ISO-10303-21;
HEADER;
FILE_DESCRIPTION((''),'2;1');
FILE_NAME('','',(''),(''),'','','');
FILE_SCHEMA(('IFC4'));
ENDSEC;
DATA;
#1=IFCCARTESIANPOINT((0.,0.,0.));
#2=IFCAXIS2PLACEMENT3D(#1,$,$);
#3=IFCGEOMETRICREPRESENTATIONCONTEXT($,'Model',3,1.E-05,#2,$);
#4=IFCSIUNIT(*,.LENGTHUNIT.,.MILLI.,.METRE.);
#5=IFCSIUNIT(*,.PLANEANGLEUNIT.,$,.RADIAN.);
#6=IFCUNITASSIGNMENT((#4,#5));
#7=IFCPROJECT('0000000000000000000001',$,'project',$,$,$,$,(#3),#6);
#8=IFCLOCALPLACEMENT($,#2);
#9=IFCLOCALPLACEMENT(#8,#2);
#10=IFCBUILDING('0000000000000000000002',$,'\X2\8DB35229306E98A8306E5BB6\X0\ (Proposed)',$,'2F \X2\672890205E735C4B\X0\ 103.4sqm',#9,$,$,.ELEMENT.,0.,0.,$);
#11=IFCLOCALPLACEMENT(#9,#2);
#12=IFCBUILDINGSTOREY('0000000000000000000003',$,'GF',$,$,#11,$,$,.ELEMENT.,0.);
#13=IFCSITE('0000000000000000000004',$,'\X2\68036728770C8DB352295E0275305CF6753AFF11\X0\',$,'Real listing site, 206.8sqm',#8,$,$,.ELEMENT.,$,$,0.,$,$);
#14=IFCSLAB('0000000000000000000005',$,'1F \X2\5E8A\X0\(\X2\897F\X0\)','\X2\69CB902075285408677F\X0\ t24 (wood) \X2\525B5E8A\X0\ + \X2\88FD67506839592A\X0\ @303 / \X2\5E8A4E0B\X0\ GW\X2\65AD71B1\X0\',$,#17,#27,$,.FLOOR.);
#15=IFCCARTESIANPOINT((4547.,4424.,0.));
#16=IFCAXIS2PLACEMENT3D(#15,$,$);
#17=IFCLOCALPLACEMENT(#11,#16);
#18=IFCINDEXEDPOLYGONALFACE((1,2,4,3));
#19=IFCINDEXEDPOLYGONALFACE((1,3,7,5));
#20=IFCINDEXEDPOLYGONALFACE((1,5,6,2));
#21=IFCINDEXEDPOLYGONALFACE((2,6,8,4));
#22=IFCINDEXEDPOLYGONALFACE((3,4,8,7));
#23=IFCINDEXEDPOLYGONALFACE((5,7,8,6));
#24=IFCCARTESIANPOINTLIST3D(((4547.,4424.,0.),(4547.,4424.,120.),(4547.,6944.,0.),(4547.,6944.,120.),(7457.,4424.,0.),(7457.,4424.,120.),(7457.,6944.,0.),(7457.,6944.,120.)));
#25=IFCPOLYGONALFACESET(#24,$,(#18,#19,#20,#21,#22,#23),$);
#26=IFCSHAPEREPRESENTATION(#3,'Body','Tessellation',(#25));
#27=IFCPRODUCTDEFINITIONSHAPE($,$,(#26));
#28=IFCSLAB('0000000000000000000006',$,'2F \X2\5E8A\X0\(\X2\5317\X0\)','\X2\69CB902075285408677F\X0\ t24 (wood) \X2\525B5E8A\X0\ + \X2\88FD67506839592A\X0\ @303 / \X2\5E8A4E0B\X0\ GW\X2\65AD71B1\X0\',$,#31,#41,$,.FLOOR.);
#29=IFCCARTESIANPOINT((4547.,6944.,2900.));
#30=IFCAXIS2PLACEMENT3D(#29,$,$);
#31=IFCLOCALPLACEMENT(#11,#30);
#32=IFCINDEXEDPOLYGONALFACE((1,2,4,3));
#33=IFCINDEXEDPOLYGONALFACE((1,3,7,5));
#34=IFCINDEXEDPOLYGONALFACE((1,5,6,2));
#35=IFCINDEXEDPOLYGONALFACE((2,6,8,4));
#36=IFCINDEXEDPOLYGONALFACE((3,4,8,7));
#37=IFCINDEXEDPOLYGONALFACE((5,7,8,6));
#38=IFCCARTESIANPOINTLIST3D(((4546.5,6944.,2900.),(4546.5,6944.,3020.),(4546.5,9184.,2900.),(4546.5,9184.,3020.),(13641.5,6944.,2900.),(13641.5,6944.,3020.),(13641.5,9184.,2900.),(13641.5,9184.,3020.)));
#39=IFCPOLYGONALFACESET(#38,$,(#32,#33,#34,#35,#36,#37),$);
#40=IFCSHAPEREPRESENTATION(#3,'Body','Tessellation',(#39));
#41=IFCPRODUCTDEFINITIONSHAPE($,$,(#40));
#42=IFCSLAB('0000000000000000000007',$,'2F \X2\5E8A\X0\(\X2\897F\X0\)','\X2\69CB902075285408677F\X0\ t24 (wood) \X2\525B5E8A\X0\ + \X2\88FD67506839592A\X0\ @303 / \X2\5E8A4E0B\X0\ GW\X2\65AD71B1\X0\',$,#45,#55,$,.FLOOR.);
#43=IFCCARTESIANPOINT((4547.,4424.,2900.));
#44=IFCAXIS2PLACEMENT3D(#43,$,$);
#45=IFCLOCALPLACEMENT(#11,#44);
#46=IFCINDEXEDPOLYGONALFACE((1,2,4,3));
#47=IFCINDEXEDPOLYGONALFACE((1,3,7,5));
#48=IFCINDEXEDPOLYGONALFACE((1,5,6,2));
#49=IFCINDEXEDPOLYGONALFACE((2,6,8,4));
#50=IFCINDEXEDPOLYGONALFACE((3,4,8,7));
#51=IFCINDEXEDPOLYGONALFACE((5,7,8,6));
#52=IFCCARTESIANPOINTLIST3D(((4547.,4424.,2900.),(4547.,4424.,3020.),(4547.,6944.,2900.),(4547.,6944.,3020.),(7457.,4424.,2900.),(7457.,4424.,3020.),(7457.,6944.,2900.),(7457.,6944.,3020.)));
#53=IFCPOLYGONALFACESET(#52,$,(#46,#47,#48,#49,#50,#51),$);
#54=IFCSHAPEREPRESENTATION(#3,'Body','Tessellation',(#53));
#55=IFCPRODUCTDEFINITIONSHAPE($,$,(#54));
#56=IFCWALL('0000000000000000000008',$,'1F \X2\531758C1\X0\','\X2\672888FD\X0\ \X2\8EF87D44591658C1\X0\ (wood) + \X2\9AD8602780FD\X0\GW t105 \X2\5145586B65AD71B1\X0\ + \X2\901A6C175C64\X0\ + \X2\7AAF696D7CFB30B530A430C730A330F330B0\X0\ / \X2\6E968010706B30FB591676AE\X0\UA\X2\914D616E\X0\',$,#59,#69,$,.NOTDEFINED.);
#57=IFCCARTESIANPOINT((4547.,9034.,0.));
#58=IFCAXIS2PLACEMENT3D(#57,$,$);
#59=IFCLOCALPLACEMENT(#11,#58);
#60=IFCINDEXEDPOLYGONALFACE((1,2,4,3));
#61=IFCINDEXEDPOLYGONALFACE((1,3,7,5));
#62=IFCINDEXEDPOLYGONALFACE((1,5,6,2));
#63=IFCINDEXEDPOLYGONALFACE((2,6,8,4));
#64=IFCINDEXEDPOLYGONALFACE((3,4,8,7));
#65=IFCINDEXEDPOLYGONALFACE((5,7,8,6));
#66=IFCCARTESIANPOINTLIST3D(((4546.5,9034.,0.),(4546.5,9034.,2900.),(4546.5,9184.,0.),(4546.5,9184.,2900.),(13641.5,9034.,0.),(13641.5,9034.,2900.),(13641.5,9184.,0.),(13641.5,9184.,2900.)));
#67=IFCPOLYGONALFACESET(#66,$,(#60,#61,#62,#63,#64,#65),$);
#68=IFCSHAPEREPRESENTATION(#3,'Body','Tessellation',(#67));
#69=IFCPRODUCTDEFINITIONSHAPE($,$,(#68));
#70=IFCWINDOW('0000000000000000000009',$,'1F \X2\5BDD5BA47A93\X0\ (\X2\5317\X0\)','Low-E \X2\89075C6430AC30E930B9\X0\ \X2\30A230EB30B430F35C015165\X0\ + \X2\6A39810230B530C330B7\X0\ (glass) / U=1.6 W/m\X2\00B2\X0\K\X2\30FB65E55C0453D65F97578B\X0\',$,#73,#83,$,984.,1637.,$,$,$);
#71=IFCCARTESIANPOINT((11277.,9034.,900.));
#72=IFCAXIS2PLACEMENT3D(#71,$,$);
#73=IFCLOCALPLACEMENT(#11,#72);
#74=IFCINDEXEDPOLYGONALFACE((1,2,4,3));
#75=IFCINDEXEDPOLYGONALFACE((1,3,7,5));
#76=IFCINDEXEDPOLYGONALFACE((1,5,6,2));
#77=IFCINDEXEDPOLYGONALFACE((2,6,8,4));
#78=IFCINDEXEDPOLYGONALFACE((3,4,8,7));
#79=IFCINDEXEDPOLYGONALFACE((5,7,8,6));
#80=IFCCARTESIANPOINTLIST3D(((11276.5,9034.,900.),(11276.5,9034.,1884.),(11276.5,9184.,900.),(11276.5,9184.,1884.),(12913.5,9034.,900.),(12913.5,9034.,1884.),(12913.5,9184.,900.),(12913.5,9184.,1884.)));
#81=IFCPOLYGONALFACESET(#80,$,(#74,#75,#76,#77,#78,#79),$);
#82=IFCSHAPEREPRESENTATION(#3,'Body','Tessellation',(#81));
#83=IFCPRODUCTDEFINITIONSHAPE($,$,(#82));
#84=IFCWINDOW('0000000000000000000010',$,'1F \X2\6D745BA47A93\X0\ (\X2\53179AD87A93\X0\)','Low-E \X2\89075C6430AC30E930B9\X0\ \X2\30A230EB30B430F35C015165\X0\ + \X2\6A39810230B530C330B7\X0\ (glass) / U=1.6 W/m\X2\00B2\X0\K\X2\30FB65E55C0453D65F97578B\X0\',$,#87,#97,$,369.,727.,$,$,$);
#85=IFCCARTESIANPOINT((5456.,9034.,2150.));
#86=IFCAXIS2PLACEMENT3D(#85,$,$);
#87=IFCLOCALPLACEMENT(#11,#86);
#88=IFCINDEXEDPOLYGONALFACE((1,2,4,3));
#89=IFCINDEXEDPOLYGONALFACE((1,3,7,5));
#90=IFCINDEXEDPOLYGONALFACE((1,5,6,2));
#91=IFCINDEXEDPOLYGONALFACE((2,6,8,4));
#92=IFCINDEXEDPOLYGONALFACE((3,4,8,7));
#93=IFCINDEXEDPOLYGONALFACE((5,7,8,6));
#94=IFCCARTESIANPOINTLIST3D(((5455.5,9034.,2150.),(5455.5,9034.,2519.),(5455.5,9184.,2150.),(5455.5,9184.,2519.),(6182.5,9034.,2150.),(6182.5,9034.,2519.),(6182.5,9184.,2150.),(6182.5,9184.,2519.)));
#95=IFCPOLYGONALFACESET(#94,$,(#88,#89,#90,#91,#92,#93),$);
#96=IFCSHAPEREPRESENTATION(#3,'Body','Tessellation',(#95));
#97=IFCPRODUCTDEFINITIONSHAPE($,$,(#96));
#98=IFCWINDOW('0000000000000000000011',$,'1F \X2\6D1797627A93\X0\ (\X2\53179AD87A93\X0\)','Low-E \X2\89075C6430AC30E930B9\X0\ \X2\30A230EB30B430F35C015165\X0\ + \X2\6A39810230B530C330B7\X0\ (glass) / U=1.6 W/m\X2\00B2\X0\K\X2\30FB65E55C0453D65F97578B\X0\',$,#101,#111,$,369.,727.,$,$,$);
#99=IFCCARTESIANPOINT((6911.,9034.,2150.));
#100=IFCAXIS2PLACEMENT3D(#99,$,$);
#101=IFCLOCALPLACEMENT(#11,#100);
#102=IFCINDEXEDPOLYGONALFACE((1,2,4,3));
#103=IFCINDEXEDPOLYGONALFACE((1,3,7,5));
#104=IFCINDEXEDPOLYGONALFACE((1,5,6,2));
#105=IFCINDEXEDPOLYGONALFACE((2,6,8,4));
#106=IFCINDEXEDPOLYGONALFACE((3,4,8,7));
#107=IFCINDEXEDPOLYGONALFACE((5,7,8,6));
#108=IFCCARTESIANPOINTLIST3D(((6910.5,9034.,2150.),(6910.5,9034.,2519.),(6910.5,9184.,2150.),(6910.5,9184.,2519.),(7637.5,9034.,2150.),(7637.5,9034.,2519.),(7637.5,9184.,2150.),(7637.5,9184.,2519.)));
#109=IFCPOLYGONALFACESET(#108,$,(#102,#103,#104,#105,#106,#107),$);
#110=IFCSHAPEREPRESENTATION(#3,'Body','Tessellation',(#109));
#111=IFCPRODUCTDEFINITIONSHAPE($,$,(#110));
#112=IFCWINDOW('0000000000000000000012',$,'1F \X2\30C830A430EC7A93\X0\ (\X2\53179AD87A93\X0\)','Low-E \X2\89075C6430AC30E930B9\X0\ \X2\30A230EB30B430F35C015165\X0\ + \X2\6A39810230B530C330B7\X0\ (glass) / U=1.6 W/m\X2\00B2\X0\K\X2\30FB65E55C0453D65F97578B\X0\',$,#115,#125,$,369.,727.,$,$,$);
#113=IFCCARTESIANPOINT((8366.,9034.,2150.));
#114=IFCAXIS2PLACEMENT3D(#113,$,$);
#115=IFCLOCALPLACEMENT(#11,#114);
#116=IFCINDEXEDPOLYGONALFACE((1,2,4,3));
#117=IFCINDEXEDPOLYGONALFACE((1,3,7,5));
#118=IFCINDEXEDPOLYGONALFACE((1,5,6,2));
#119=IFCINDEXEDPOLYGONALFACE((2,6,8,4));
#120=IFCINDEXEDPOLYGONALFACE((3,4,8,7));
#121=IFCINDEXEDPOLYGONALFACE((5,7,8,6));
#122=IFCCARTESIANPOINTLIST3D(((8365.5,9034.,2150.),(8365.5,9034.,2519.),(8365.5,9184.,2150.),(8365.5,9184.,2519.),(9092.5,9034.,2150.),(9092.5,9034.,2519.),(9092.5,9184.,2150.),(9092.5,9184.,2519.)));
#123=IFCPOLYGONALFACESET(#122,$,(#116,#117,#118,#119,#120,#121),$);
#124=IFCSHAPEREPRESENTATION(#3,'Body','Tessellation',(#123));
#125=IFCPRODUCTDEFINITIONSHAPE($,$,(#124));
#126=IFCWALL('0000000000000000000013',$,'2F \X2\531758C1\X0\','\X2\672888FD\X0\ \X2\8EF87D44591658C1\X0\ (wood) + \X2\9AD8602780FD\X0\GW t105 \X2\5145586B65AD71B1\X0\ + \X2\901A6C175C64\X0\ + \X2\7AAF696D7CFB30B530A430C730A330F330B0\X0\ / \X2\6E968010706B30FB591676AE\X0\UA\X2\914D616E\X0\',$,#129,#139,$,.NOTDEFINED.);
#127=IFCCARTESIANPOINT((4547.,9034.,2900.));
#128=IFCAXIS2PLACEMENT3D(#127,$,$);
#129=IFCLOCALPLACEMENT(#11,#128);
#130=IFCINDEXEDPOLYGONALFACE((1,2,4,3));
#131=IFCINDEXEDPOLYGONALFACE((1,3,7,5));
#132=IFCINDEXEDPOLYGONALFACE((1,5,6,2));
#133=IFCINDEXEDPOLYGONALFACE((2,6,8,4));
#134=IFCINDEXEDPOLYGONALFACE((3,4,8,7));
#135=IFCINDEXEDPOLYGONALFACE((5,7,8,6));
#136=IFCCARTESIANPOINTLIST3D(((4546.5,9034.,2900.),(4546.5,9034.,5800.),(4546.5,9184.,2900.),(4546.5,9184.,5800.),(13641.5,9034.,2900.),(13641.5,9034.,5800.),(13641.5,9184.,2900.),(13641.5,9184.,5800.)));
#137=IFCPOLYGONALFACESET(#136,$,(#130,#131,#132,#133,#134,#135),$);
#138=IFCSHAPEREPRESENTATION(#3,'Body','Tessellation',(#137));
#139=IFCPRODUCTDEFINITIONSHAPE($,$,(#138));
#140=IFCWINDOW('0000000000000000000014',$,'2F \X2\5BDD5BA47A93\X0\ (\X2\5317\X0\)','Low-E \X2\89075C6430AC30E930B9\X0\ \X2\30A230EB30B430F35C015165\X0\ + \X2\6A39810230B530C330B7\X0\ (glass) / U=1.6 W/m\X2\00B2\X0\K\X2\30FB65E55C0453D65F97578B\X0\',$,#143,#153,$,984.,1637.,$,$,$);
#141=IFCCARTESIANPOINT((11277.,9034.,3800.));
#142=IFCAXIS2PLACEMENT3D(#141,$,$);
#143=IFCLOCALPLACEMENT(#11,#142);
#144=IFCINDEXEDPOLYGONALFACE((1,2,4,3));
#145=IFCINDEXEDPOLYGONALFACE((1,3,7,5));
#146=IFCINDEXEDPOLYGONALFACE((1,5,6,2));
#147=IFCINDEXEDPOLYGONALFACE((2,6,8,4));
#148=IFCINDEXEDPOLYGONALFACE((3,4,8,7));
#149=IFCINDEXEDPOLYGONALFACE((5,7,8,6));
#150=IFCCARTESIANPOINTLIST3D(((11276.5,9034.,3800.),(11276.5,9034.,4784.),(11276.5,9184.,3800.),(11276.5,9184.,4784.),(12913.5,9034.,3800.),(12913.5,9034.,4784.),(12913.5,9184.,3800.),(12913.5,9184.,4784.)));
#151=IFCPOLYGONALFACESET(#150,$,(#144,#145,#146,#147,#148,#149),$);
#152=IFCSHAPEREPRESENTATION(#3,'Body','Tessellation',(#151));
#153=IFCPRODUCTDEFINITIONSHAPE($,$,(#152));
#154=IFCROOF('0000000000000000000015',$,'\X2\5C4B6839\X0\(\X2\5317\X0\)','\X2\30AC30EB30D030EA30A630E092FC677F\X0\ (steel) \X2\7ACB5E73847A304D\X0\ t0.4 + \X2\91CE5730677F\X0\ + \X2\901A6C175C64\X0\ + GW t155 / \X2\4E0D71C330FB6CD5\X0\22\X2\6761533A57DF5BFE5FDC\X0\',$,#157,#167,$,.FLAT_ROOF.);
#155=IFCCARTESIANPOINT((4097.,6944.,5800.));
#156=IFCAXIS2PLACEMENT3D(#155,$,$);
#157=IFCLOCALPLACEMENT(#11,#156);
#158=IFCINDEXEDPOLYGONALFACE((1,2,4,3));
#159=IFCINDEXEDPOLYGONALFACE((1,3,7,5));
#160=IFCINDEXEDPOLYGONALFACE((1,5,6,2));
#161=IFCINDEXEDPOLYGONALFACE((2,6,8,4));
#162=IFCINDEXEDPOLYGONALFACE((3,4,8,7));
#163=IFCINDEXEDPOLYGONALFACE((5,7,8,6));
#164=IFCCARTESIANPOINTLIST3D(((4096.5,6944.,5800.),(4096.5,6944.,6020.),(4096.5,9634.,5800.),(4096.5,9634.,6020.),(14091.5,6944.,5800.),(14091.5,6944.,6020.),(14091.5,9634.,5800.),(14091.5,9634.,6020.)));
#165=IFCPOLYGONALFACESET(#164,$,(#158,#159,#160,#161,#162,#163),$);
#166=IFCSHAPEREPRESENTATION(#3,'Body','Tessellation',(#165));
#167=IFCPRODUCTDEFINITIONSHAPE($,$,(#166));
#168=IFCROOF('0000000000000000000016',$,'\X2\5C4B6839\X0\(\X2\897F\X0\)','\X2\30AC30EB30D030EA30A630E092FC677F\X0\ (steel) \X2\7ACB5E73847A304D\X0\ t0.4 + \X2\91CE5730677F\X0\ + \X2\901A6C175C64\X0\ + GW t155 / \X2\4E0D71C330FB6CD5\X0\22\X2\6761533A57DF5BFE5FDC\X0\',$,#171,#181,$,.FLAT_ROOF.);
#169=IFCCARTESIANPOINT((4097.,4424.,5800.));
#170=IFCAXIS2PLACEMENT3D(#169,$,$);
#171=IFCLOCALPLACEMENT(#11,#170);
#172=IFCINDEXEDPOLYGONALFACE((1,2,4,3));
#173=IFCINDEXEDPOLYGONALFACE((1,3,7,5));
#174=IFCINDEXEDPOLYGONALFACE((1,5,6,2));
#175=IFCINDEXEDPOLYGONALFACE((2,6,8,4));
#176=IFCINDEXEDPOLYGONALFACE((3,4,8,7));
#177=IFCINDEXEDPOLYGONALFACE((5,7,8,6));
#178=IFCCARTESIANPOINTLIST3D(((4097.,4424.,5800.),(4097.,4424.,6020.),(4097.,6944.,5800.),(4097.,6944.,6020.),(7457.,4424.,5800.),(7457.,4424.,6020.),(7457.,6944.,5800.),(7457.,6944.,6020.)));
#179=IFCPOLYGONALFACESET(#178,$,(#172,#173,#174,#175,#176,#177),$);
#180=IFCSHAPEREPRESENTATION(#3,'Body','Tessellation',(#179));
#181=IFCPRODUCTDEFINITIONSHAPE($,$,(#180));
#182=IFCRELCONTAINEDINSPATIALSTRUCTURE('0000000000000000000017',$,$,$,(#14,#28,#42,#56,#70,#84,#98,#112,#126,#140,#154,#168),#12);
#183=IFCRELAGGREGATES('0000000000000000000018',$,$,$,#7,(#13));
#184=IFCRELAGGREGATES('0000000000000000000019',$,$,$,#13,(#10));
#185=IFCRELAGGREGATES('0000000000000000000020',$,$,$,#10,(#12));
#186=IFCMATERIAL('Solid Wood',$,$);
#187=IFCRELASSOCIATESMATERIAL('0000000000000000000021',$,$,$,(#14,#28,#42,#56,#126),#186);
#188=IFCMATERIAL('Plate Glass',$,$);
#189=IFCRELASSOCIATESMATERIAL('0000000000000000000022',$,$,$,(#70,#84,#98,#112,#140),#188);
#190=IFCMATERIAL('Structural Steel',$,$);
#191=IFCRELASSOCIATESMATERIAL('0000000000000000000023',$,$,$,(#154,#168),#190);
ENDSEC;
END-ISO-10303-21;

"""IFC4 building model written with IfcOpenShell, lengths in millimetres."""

from ifc_helpers import new_model, si_unit, frame, frame_2d, origin, place, context, project, spatial, rectangle, extrude, material, element, fill, save


model = new_model("IFC4")

# Units and contexts
model_context = context("Model", 3, precision=1e-05, world=origin())
ifc_project = project(units=[si_unit("LENGTHUNIT", "METRE", prefix="MILLI"), si_unit("PLANEANGLEUNIT", "RADIAN")], contexts=[model_context])

# Site, building, storey
site_placement = place(None, origin())
site = spatial("IfcSite", under=ifc_project, at=site_placement, Name="栃木県足利市田島町１", ObjectType="Real listing site, 206.8sqm", CompositionType="ELEMENT", RefElevation=0.0)
building_placement = place(site_placement, origin())
building = spatial("IfcBuilding", under=site, at=building_placement, Name="足利の風の家 (Proposed)", ObjectType="2F 木造平屋 103.4sqm", CompositionType="ELEMENT", ElevationOfRefHeight=0.0, ElevationOfTerrain=0.0)
storey_placement = place(building_placement, origin())
storey = spatial("IfcBuildingStorey", under=building, at=storey_placement, Name="GF", CompositionType="ELEMENT", Elevation=0.0)

# Slabs
ifc_material_1 = material(Name="Solid Wood")
slab_1_placement = place(storey_placement, frame((4547.0, 4424.0, 0.0)))
element("IfcSlab", 1, at=slab_1_placement, inside=storey, material=ifc_material_1, Name="1F 床(西)", Description="構造用合板 t24 (wood) 剛床 + 製材根太 @303 / 床下 GW断熱", PredefinedType="FLOOR", context=model_context, shape_type="SweptSolid", body=[
    extrude(rectangle(XDim=2910.0, YDim=2520.0, at=frame_2d((1455.0, 1260.0))), frame((4547.0, 4424.0, 0.0)), (0.0, 0.0, 1.0), 120.0),
])
slab_2_placement = place(storey_placement, frame((4547.0, 6944.0, 2900.0)))
element("IfcSlab", 2, at=slab_2_placement, inside=storey, material=ifc_material_1, Name="2F 床(北)", Description="構造用合板 t24 (wood) 剛床 + 製材根太 @303 / 床下 GW断熱", PredefinedType="FLOOR", context=model_context, shape_type="SweptSolid", body=[
    extrude(rectangle(XDim=9095.0, YDim=2240.0, at=frame_2d((4547.0, 1120.0))), frame((4547.0, 6944.0, 2900.0)), (0.0, 0.0, 1.0), 120.0),
])
slab_3_placement = place(storey_placement, frame((4547.0, 4424.0, 2900.0)))
element("IfcSlab", 3, at=slab_3_placement, inside=storey, material=ifc_material_1, Name="2F 床(西)", Description="構造用合板 t24 (wood) 剛床 + 製材根太 @303 / 床下 GW断熱", PredefinedType="FLOOR", context=model_context, shape_type="SweptSolid", body=[
    extrude(rectangle(XDim=2910.0, YDim=2520.0, at=frame_2d((1455.0, 1260.0))), frame((4547.0, 4424.0, 2900.0)), (0.0, 0.0, 1.0), 120.0),
])

# Wall, openings, windows
wall_1_placement = place(storey_placement, frame((4547.0, 9034.0, 0.0)))
wall_1 = element("IfcWall", 4, at=wall_1_placement, inside=storey, material=ifc_material_1, Name="1F 北壁", Description="木製 軸組外壁 (wood) + 高性能GW t105 充填断熱 + 通気層 + 窯業系サイディング / 準耐火・外皮UA配慮", PredefinedType="NOTDEFINED", context=model_context, shape_type="SweptSolid", body=[
    extrude(rectangle(XDim=9095.0, YDim=150.0, at=frame_2d((4547.0, 75.0))), frame((4547.0, 9034.0, 0.0)), (0.0, 0.0, 1.0), 2900.0),
])
opening_1_placement = place(storey_placement, frame((11277.0, 9034.0, 900.0)))
opening_1 = element("IfcOpeningElement", 5, at=opening_1_placement, cuts=wall_1, PredefinedType="NOTDEFINED", context=model_context, shape_type="SweptSolid", body=[
    extrude(rectangle(XDim=1637.0, YDim=150.0, at=frame_2d((818.0, 75.0))), frame((11277.0, 9034.0, 900.0)), (0.0, 0.0, 1.0), 984.0),
])
opening_2_placement = place(storey_placement, frame((5456.0, 9034.0, 2150.0)))
opening_2 = element("IfcOpeningElement", 6, at=opening_2_placement, cuts=wall_1, PredefinedType="NOTDEFINED", context=model_context, shape_type="SweptSolid", body=[
    extrude(rectangle(XDim=727.0, YDim=150.0, at=frame_2d((363.0, 75.0))), frame((5456.0, 9034.0, 2150.0)), (0.0, 0.0, 1.0), 369.0),
])
opening_3_placement = place(storey_placement, frame((6911.0, 9034.0, 2150.0)))
opening_3 = element("IfcOpeningElement", 7, at=opening_3_placement, cuts=wall_1, PredefinedType="NOTDEFINED", context=model_context, shape_type="SweptSolid", body=[
    extrude(rectangle(XDim=727.0, YDim=150.0, at=frame_2d((363.0, 75.0))), frame((6911.0, 9034.0, 2150.0)), (0.0, 0.0, 1.0), 369.0),
])
opening_4_placement = place(storey_placement, frame((8366.0, 9034.0, 2150.0)))
opening_4 = element("IfcOpeningElement", 8, at=opening_4_placement, cuts=wall_1, PredefinedType="NOTDEFINED", context=model_context, shape_type="SweptSolid", body=[
    extrude(rectangle(XDim=727.0, YDim=150.0, at=frame_2d((363.0, 75.0))), frame((8366.0, 9034.0, 2150.0)), (0.0, 0.0, 1.0), 369.0),
])
ifc_material_2 = material(Name="Plate Glass")
window_1_placement = place(storey_placement, frame((11277.0, 9034.0, 900.0)))
window_1 = element("IfcWindow", 9, at=window_1_placement, inside=storey, material=ifc_material_2, Name="1F 寝室窓 (北)", Description="Low-E 複層ガラス アルゴン封入 + 樹脂サッシ (glass) / U=1.6 W/m²K・日射取得型", OverallHeight=984.0, OverallWidth=1637.0, context=model_context, shape_type="SweptSolid", body=[
    extrude(rectangle(XDim=1637.0, YDim=150.0, at=frame_2d((818.0, 75.0))), frame((11277.0, 9034.0, 900.0)), (0.0, 0.0, 1.0), 984.0),
])
fill(opening_1, window_1)
window_2_placement = place(storey_placement, frame((5456.0, 9034.0, 2150.0)))
window_2 = element("IfcWindow", 10, at=window_2_placement, inside=storey, material=ifc_material_2, Name="1F 浴室窓 (北高窓)", Description="Low-E 複層ガラス アルゴン封入 + 樹脂サッシ (glass) / U=1.6 W/m²K・日射取得型", OverallHeight=369.0, OverallWidth=727.0, context=model_context, shape_type="SweptSolid", body=[
    extrude(rectangle(XDim=727.0, YDim=150.0, at=frame_2d((363.0, 75.0))), frame((5456.0, 9034.0, 2150.0)), (0.0, 0.0, 1.0), 369.0),
])
fill(opening_2, window_2)
window_3_placement = place(storey_placement, frame((6911.0, 9034.0, 2150.0)))
window_3 = element("IfcWindow", 11, at=window_3_placement, inside=storey, material=ifc_material_2, Name="1F 洗面窓 (北高窓)", Description="Low-E 複層ガラス アルゴン封入 + 樹脂サッシ (glass) / U=1.6 W/m²K・日射取得型", OverallHeight=369.0, OverallWidth=727.0, context=model_context, shape_type="SweptSolid", body=[
    extrude(rectangle(XDim=727.0, YDim=150.0, at=frame_2d((363.0, 75.0))), frame((6911.0, 9034.0, 2150.0)), (0.0, 0.0, 1.0), 369.0),
])
fill(opening_3, window_3)
window_4_placement = place(storey_placement, frame((8366.0, 9034.0, 2150.0)))
window_4 = element("IfcWindow", 12, at=window_4_placement, inside=storey, material=ifc_material_2, Name="1F トイレ窓 (北高窓)", Description="Low-E 複層ガラス アルゴン封入 + 樹脂サッシ (glass) / U=1.6 W/m²K・日射取得型", OverallHeight=369.0, OverallWidth=727.0, context=model_context, shape_type="SweptSolid", body=[
    extrude(rectangle(XDim=727.0, YDim=150.0, at=frame_2d((363.0, 75.0))), frame((8366.0, 9034.0, 2150.0)), (0.0, 0.0, 1.0), 369.0),
])
fill(opening_4, window_4)

# Wall, opening, window
wall_2_placement = place(storey_placement, frame((4547.0, 9034.0, 2900.0)))
wall_2 = element("IfcWall", 13, at=wall_2_placement, inside=storey, material=ifc_material_1, Name="2F 北壁", Description="木製 軸組外壁 (wood) + 高性能GW t105 充填断熱 + 通気層 + 窯業系サイディング / 準耐火・外皮UA配慮", PredefinedType="NOTDEFINED", context=model_context, shape_type="SweptSolid", body=[
    extrude(rectangle(XDim=9095.0, YDim=150.0, at=frame_2d((4547.0, 75.0))), frame((4547.0, 9034.0, 2900.0)), (0.0, 0.0, 1.0), 2900.0),
])
opening_5_placement = place(storey_placement, frame((11277.0, 9034.0, 3800.0)))
opening_5 = element("IfcOpeningElement", 14, at=opening_5_placement, cuts=wall_2, PredefinedType="NOTDEFINED", context=model_context, shape_type="SweptSolid", body=[
    extrude(rectangle(XDim=1637.0, YDim=150.0, at=frame_2d((818.0, 75.0))), frame((11277.0, 9034.0, 3800.0)), (0.0, 0.0, 1.0), 984.0),
])
window_5_placement = place(storey_placement, frame((11277.0, 9034.0, 3800.0)))
window_5 = element("IfcWindow", 15, at=window_5_placement, inside=storey, material=ifc_material_2, Name="2F 寝室窓 (北)", Description="Low-E 複層ガラス アルゴン封入 + 樹脂サッシ (glass) / U=1.6 W/m²K・日射取得型", OverallHeight=984.0, OverallWidth=1637.0, context=model_context, shape_type="SweptSolid", body=[
    extrude(rectangle(XDim=1637.0, YDim=150.0, at=frame_2d((818.0, 75.0))), frame((11277.0, 9034.0, 3800.0)), (0.0, 0.0, 1.0), 984.0),
])
fill(opening_5, window_5)

# Roofs
ifc_material_3 = material(Name="Structural Steel")
for number, where, name in (
    (16, (4097.0, 6944.0, 5800.0), "屋根(北)"),
):
    element("IfcRoof", number, at=place(storey_placement, frame(where)), inside=storey, material=ifc_material_3, Name=name, Description="ガルバリウム鋼板 (steel) 立平葺き t0.4 + 野地板 + 通気層 + GW t155 / 不燃・法22条区域対応", PredefinedType="FLAT_ROOF", context=model_context, shape_type="SweptSolid", body=[
        extrude(rectangle(XDim=9995.0, YDim=2690.0, at=frame_2d((4997.0, 1345.0))), frame((4097.0, 6944.0, 5800.0)), (0.0, 0.0, 1.0), 220.0),
    ])
roof_placement = place(storey_placement, frame((4097.0, 4424.0, 5800.0)))
element("IfcRoof", 17, at=roof_placement, inside=storey, material=ifc_material_3, Name="屋根(西)", Description="ガルバリウム鋼板 (steel) 立平葺き t0.4 + 野地板 + 通気層 + GW t155 / 不燃・法22条区域対応", PredefinedType="FLAT_ROOF", context=model_context, shape_type="SweptSolid", body=[
    extrude(rectangle(XDim=3360.0, YDim=2520.0, at=frame_2d((1680.0, 1260.0))), frame((4097.0, 4424.0, 5800.0)), (0.0, 0.0, 1.0), 220.0),
])

save(model, "model.ifc")
